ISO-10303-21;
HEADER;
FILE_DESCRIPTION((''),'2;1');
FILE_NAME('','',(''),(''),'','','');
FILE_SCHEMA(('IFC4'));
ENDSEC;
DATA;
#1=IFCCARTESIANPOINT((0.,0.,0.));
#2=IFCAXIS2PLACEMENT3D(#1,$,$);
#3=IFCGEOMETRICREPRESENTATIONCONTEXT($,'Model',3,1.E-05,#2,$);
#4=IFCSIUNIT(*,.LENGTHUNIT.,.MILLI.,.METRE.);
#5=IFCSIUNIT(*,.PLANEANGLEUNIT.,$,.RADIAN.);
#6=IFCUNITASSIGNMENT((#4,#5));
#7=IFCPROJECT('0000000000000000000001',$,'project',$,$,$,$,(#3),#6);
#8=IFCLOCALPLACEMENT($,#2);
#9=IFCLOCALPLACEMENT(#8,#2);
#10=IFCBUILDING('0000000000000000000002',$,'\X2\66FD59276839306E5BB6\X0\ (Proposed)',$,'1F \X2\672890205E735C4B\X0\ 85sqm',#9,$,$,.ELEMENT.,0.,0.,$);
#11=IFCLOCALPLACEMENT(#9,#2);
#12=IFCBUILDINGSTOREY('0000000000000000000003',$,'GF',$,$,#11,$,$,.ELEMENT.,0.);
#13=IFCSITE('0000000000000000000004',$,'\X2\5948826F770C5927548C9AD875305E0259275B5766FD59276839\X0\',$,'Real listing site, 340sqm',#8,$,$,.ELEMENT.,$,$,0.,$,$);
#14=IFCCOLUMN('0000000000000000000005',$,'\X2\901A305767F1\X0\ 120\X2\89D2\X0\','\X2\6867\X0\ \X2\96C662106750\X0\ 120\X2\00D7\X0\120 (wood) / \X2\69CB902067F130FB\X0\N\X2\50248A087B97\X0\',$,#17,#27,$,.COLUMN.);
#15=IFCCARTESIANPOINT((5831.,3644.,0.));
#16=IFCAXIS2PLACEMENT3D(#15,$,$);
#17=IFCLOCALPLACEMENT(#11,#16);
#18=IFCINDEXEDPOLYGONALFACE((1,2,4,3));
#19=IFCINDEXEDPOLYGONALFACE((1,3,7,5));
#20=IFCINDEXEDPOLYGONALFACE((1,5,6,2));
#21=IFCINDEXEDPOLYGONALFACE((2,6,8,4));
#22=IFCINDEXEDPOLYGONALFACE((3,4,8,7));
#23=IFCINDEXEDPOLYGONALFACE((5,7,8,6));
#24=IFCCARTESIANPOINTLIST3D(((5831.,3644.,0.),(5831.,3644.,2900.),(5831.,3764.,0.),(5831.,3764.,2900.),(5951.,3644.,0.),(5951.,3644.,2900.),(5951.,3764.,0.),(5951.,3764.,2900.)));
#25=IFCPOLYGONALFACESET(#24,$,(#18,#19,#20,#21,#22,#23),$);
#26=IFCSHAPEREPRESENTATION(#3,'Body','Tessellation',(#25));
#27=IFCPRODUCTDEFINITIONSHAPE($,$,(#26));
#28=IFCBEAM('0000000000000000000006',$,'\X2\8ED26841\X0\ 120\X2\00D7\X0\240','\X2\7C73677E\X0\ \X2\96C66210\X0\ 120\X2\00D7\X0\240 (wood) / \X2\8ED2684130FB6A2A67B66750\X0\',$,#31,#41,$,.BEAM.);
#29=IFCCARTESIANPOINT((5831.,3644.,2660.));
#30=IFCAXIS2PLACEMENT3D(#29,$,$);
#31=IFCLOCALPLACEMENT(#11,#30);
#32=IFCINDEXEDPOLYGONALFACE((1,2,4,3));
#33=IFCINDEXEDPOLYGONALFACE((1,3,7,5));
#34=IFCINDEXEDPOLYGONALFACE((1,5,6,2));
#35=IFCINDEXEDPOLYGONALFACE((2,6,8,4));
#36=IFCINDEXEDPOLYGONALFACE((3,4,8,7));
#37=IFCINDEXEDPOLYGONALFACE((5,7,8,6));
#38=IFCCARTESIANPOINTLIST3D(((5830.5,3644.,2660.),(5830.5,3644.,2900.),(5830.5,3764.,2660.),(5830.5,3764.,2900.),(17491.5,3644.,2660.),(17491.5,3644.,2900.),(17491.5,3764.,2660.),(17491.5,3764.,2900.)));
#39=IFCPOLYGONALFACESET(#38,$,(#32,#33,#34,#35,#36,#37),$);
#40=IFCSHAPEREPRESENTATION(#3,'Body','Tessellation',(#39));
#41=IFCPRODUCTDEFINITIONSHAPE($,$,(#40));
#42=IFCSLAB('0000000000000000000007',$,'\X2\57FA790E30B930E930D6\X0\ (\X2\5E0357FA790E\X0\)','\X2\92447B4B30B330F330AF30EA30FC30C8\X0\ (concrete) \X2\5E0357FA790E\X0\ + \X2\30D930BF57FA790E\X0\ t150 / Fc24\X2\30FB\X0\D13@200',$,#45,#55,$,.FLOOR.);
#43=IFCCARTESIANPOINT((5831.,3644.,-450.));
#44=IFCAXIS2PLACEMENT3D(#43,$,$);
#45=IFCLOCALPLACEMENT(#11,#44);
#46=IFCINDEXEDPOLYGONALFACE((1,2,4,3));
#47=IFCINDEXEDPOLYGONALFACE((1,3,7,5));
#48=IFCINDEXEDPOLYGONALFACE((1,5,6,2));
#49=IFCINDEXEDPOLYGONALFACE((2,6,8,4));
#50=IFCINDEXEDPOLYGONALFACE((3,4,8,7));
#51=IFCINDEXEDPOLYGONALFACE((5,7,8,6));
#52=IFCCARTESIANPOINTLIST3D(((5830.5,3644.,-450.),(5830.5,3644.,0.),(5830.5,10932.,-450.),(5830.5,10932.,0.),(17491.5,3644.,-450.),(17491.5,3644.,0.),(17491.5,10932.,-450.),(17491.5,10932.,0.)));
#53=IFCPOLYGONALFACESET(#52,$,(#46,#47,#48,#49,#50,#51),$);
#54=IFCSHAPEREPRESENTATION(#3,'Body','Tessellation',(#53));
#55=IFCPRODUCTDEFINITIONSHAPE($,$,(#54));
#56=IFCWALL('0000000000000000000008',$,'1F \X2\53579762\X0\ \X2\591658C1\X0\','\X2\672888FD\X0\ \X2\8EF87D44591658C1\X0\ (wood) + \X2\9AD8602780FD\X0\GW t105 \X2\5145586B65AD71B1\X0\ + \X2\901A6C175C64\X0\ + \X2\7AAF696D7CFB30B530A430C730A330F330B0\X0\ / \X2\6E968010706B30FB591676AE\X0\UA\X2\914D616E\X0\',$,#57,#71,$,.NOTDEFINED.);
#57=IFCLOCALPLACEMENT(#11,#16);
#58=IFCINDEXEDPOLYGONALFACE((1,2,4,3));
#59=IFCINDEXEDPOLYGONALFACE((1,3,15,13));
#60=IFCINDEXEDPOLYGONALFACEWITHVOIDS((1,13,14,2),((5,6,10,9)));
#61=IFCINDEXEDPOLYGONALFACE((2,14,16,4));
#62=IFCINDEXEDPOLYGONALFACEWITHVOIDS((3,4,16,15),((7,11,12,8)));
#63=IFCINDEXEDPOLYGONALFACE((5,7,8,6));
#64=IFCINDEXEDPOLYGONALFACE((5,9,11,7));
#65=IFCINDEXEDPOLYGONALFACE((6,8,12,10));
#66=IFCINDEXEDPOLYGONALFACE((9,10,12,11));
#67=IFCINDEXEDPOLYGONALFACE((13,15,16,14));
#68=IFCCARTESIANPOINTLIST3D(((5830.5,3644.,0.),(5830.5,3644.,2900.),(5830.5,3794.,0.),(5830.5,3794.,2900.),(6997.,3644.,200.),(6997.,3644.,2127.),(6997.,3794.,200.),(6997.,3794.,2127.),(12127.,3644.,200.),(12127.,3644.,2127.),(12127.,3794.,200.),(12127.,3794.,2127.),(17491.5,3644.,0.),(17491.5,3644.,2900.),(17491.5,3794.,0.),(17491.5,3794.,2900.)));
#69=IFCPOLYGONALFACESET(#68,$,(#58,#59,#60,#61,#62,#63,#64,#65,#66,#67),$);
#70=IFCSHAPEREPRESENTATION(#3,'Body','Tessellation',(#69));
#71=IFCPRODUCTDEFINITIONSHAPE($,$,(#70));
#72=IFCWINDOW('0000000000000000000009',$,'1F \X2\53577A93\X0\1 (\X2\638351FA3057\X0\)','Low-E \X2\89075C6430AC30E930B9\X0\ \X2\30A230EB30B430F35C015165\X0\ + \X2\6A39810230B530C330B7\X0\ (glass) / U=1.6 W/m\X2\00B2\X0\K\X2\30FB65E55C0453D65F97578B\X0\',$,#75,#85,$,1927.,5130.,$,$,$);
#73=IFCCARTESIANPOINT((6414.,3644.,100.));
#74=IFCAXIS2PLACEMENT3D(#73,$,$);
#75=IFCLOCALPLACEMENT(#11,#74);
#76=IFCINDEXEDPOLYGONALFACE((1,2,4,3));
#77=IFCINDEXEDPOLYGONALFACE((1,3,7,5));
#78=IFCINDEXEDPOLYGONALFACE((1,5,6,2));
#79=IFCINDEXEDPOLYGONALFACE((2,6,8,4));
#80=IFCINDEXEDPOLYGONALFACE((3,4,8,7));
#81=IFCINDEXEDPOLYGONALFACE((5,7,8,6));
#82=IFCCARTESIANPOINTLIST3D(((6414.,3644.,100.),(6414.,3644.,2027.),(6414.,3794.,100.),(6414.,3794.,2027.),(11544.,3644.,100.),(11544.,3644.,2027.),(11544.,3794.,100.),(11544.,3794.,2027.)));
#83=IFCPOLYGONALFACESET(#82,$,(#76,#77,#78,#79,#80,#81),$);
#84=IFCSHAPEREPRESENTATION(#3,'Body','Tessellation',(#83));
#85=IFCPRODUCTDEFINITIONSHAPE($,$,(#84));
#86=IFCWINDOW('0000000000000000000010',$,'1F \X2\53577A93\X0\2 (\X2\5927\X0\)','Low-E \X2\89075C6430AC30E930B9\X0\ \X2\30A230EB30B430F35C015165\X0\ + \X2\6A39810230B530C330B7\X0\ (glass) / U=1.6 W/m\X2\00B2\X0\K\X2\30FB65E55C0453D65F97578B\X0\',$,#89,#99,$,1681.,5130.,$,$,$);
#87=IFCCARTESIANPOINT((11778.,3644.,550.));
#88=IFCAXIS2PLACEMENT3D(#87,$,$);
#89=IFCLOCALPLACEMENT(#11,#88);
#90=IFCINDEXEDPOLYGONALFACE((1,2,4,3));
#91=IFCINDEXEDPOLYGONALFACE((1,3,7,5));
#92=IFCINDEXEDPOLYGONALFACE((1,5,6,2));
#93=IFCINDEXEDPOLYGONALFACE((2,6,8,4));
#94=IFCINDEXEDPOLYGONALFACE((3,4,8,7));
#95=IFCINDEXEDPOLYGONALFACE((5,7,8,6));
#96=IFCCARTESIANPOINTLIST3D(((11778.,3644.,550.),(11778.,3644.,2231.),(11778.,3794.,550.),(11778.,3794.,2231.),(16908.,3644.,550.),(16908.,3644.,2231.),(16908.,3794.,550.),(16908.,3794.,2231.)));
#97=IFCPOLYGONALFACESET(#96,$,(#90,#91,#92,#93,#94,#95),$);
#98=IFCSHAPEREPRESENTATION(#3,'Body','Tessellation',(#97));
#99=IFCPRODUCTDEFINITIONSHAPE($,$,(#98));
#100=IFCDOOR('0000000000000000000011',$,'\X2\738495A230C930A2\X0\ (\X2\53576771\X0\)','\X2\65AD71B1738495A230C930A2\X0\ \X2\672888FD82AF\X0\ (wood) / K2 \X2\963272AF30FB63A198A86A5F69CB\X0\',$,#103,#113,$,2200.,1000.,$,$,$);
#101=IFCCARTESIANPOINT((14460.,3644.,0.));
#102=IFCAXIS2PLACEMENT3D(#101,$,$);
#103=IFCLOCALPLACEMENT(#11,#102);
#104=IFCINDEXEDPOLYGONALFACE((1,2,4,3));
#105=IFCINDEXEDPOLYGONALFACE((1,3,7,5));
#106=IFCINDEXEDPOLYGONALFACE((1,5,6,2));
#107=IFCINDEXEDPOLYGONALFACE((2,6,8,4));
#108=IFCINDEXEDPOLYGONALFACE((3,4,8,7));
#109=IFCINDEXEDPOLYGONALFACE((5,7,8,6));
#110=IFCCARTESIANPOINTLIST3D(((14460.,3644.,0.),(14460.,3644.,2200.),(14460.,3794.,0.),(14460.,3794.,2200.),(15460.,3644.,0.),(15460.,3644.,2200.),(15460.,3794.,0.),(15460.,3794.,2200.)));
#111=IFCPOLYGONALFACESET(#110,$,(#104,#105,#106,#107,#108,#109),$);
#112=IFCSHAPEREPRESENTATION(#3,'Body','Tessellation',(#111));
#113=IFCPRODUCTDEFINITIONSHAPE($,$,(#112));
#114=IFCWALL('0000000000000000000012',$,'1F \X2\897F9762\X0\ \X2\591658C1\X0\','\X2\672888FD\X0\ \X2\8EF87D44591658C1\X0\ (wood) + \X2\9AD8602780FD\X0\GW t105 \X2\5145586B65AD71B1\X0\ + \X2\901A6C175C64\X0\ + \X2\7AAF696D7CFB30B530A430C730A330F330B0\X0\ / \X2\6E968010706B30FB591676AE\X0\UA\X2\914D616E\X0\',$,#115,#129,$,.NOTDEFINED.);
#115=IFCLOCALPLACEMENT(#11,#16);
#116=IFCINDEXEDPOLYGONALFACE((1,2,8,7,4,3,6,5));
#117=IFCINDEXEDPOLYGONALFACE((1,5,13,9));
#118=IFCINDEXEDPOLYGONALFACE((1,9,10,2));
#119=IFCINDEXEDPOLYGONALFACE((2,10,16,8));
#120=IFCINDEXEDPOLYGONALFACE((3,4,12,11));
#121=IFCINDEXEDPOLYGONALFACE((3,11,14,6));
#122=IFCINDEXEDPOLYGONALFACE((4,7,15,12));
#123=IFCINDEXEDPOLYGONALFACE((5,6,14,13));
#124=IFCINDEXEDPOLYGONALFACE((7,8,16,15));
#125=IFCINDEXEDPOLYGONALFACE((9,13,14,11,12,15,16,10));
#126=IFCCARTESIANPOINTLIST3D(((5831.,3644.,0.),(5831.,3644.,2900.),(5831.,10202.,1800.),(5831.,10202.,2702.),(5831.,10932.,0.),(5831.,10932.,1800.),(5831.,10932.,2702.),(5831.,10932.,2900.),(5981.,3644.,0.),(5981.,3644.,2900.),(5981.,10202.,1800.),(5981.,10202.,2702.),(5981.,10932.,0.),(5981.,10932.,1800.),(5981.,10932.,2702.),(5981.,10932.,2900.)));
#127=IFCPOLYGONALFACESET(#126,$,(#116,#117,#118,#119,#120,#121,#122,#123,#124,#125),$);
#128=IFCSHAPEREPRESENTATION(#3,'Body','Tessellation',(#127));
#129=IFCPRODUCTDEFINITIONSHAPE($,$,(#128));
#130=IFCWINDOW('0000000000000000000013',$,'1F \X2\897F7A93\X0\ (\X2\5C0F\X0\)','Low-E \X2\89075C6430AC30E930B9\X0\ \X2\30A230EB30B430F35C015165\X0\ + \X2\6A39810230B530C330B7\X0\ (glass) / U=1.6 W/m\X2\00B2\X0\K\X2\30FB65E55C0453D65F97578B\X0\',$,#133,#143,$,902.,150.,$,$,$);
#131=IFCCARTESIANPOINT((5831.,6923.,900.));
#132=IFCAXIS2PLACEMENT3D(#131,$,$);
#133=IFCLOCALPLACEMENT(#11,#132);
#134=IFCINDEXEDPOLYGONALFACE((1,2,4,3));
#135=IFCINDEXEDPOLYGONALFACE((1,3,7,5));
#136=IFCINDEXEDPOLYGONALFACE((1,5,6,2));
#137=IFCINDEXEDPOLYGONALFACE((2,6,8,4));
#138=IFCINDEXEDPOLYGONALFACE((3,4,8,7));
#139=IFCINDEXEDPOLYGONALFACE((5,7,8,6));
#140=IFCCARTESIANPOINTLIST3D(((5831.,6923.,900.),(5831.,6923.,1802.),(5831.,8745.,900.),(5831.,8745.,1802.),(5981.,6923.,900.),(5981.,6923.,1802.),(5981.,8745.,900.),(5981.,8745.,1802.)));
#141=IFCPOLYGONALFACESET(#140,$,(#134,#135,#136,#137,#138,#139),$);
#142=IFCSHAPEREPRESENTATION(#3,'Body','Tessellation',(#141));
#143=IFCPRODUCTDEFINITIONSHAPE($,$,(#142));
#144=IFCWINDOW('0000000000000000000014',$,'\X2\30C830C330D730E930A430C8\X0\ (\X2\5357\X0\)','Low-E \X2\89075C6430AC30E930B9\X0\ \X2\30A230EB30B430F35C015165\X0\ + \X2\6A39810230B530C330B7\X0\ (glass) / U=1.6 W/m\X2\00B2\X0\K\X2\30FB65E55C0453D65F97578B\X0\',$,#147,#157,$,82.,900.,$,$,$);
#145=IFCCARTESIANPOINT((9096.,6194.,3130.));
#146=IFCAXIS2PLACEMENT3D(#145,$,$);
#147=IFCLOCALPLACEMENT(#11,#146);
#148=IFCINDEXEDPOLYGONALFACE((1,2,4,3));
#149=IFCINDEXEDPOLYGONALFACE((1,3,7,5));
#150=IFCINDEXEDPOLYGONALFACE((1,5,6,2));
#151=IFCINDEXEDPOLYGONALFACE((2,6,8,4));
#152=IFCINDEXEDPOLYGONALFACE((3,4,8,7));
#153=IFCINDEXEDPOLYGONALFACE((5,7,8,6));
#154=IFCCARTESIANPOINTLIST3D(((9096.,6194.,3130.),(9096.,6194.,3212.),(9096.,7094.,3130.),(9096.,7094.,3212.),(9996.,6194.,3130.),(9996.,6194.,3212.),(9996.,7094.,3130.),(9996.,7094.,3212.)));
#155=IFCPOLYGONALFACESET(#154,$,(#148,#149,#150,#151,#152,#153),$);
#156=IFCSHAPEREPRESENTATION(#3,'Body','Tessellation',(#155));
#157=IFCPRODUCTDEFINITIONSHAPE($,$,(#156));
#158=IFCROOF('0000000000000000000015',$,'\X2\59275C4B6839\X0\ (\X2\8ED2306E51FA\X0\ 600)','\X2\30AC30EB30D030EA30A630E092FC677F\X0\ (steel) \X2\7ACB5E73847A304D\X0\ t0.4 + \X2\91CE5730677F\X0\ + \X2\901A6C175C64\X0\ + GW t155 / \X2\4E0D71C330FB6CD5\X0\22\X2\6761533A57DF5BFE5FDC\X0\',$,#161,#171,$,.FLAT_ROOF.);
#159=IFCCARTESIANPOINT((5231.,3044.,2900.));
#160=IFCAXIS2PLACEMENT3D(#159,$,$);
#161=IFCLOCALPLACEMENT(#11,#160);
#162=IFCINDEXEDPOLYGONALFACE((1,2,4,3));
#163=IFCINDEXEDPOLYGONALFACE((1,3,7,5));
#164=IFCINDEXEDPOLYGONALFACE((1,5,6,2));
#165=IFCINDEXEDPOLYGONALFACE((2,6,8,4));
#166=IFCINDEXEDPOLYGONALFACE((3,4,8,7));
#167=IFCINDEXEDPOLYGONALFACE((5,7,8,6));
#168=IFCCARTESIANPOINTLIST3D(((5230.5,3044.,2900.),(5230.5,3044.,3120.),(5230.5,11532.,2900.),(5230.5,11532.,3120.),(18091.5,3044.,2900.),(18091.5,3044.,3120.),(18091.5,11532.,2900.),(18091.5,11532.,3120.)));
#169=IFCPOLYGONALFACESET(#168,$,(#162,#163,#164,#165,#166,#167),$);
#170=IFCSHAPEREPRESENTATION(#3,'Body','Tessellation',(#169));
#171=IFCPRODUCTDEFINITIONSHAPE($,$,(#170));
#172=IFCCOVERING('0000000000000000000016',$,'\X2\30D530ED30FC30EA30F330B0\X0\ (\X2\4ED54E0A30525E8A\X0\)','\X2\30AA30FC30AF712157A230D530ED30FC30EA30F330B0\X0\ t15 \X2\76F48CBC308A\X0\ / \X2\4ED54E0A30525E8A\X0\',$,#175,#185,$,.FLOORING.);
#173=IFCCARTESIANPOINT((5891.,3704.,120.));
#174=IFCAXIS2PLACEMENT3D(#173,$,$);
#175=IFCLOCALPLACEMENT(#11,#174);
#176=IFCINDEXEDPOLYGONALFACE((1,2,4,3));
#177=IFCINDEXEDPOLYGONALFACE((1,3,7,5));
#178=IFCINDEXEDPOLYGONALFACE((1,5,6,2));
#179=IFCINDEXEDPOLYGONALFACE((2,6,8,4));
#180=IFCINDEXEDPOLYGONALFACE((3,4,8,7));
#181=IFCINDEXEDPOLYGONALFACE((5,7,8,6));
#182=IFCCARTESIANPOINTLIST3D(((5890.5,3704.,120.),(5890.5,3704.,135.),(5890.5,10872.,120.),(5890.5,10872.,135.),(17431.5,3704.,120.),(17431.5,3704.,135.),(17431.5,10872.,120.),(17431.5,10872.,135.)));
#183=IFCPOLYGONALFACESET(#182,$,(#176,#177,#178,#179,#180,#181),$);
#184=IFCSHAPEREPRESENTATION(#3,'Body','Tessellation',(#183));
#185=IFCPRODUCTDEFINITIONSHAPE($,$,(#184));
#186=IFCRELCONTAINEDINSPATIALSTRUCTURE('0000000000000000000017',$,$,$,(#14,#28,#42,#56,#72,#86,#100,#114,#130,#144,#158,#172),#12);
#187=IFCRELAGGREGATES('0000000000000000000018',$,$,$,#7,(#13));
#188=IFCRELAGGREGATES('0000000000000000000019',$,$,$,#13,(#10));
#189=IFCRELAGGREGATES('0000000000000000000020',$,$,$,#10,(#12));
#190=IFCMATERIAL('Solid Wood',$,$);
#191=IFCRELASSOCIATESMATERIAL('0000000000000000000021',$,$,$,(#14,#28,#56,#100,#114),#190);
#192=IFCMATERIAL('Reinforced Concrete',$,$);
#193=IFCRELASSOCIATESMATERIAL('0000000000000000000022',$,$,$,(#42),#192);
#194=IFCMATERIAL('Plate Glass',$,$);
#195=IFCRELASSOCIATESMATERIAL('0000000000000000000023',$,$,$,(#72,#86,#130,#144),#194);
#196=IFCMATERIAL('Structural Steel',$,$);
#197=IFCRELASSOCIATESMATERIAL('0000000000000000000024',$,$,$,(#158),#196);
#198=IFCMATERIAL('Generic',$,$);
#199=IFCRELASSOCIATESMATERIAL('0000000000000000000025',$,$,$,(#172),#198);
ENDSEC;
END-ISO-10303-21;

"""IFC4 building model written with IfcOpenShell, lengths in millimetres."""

from ifc_helpers import new_model, si_unit, frame, frame_2d, origin, place, context, project, spatial, rectangle, extrude, material, element, fill, save


model = new_model("IFC4")

# Units and contexts
model_context = context("Model", 3, precision=1e-05, world=origin())
ifc_project = project(units=[si_unit("LENGTHUNIT", "METRE", prefix="MILLI"), si_unit("PLANEANGLEUNIT", "RADIAN")], contexts=[model_context])

# Site, building, storey
site_placement = place(None, origin())
site = spatial("IfcSite", under=ifc_project, at=site_placement, Name="奈良県大和高田市大字曽大根", ObjectType="Real listing site, 340sqm", CompositionType="ELEMENT", RefElevation=0.0)
building_placement = place(site_placement, origin())
building = spatial("IfcBuilding", under=site, at=building_placement, Name="曽大根の家 (Proposed)", ObjectType="1F 木造平屋 85sqm", CompositionType="ELEMENT", ElevationOfRefHeight=0.0, ElevationOfTerrain=0.0)
storey_placement = place(building_placement, origin())
storey = spatial("IfcBuildingStorey", under=building, at=storey_placement, Name="GF", CompositionType="ELEMENT", Elevation=0.0)

# Column
ifc_material_1 = material(Name="Solid Wood")
column_1_placement = place(storey_placement, frame((5831.0, 3644.0, 0.0)))
element("IfcColumn", 1, at=column_1_placement, inside=storey, material=ifc_material_1, Name="通し柱 120角", Description="桧 集成材 120×120 (wood) / 構造柱・N値計算", PredefinedType="COLUMN", context=model_context, shape_type="SweptSolid", body=[
    extrude(rectangle(XDim=120.0, YDim=120.0, at=frame_2d((60.0, 60.0))), frame((5831.0, 3644.0, 0.0)), (0.0, 0.0, 1.0), 2900.0),
])

# Beam
beam_1_placement = place(storey_placement, frame((5831.0, 3644.0, 2660.0)))
element("IfcBeam", 2, at=beam_1_placement, inside=storey, material=ifc_material_1, Name="軒桁 120×240", Description="米松 集成 120×240 (wood) / 軒桁・横架材", PredefinedType="BEAM", context=model_context, shape_type="SweptSolid", body=[
    extrude(rectangle(XDim=11661.0, YDim=120.0, at=frame_2d((5830.0, 60.0))), frame((5831.0, 3644.0, 2660.0)), (0.0, 0.0, 1.0), 240.0),
])

# Slab
ifc_material_2 = material(Name="Reinforced Concrete")
slab_1_placement = place(storey_placement, frame((5831.0, 3644.0, -450.0)))
element("IfcSlab", 3, at=slab_1_placement, inside=storey, material=ifc_material_2, Name="基礎スラブ (布基礎)", Description="鉄筋コンクリート (concrete) 布基礎 + ベタ基礎 t150 / Fc24・D13@200", PredefinedType="FLOOR", context=model_context, shape_type="SweptSolid", body=[
    extrude(rectangle(XDim=11661.0, YDim=7288.0, at=frame_2d((5830.0, 3644.0))), frame((5831.0, 3644.0, -450.0)), (0.0, 0.0, 1.0), 450.0),
])

# Wall, openings, windows, door
wall_1_placement = place(storey_placement, frame((5831.0, 3644.0, 0.0)))
wall_1 = element("IfcWall", 4, at=wall_1_placement, inside=storey, material=ifc_material_1, Name="1F 南面 外壁", Description="木製 軸組外壁 (wood) + 高性能GW t105 充填断熱 + 通気層 + 窯業系サイディング / 準耐火・外皮UA配慮", PredefinedType="NOTDEFINED", context=model_context, shape_type="SweptSolid", body=[
    extrude(rectangle(XDim=11661.0, YDim=150.0, at=frame_2d((5830.0, 75.0))), frame((5831.0, 3644.0, 0.0)), (0.0, 0.0, 1.0), 2900.0),
])
opening_1_placement = place(storey_placement, frame((6414.0, 3644.0, 100.0)))
opening_1 = element("IfcOpeningElement", 5, at=opening_1_placement, cuts=wall_1, PredefinedType="NOTDEFINED", context=model_context, shape_type="SweptSolid", body=[
    extrude(rectangle(XDim=5130.0, YDim=150.0, at=frame_2d((2565.0, 75.0))), frame((6414.0, 3644.0, 100.0)), (0.0, 0.0, 1.0), 1927.0),
])
opening_2_placement = place(storey_placement, frame((11778.0, 3644.0, 550.0)))
opening_2 = element("IfcOpeningElement", 6, at=opening_2_placement, cuts=wall_1, PredefinedType="NOTDEFINED", context=model_context, shape_type="SweptSolid", body=[
    extrude(rectangle(XDim=5130.0, YDim=150.0, at=frame_2d((2565.0, 75.0))), frame((11778.0, 3644.0, 550.0)), (0.0, 0.0, 1.0), 1681.0),
])
opening_3_placement = place(storey_placement, frame((14460.0, 3644.0, 0.0)))
opening_3 = element("IfcOpeningElement", 7, at=opening_3_placement, cuts=wall_1, PredefinedType="NOTDEFINED", context=model_context, shape_type="SweptSolid", body=[
    extrude(rectangle(XDim=1000.0, YDim=150.0, at=frame_2d((500.0, 75.0))), frame((14460.0, 3644.0, 0.0)), (0.0, 0.0, 1.0), 2200.0),
])
ifc_material_3 = material(Name="Plate Glass")
window_1_placement = place(storey_placement, frame((6414.0, 3644.0, 100.0)))
window_1 = element("IfcWindow", 8, at=window_1_placement, inside=storey, material=ifc_material_3, Name="1F 南窓1 (掃出し)", Description="Low-E 複層ガラス アルゴン封入 + 樹脂サッシ (glass) / U=1.6 W/m²K・日射取得型", OverallHeight=1927.0, OverallWidth=5130.0, context=model_context, shape_type="SweptSolid", body=[
    extrude(rectangle(XDim=5130.0, YDim=150.0, at=frame_2d((2565.0, 75.0))), frame((6414.0, 3644.0, 100.0)), (0.0, 0.0, 1.0), 1927.0),
])
fill(opening_1, window_1)
window_2_placement = place(storey_placement, frame((11778.0, 3644.0, 550.0)))
window_2 = element("IfcWindow", 9, at=window_2_placement, inside=storey, material=ifc_material_3, Name="1F 南窓2 (大)", Description="Low-E 複層ガラス アルゴン封入 + 樹脂サッシ (glass) / U=1.6 W/m²K・日射取得型", OverallHeight=1681.0, OverallWidth=5130.0, context=model_context, shape_type="SweptSolid", body=[
    extrude(rectangle(XDim=5130.0, YDim=150.0, at=frame_2d((2565.0, 75.0))), frame((11778.0, 3644.0, 550.0)), (0.0, 0.0, 1.0), 1681.0),
])
fill(opening_2, window_2)
door_placement = place(storey_placement, frame((14460.0, 3644.0, 0.0)))
door = element("IfcDoor", 10, at=door_placement, inside=storey, material=ifc_material_1, Name="玄関ドア (南東)", Description="断熱玄関ドア 木製芯 (wood) / K2 防犯・採風機構", OverallHeight=2200.0, OverallWidth=1000.0, context=model_context, shape_type="SweptSolid", body=[
    extrude(rectangle(XDim=1000.0, YDim=150.0, at=frame_2d((500.0, 75.0))), frame((14460.0, 3644.0, 0.0)), (0.0, 0.0, 1.0), 2200.0),
])
fill(opening_3, door)

# Wall, opening, window
wall_2_placement = place(storey_placement, frame((5831.0, 3644.0, 0.0)))
wall_2 = element("IfcWall", 11, at=wall_2_placement, inside=storey, material=ifc_material_1, Name="1F 西面 外壁", Description="木製 軸組外壁 (wood) + 高性能GW t105 充填断熱 + 通気層 + 窯業系サイディング / 準耐火・外皮UA配慮", PredefinedType="NOTDEFINED", context=model_context, shape_type="SweptSolid", body=[
    extrude(rectangle(XDim=150.0, YDim=7288.0, at=frame_2d((75.0, 3644.0))), frame((5831.0, 3644.0, 0.0)), (0.0, 0.0, 1.0), 2900.0),
])
opening_4_placement = place(storey_placement, frame((5831.0, 6923.0, 900.0)))
opening_4 = element("IfcOpeningElement", 12, at=opening_4_placement, cuts=wall_2, PredefinedType="NOTDEFINED", context=model_context, shape_type="SweptSolid", body=[
    extrude(rectangle(XDim=150.0, YDim=1822.0, at=frame_2d((75.0, 911.0))), frame((5831.0, 6923.0, 900.0)), (0.0, 0.0, 1.0), 902.0),
])
window_3_placement = place(storey_placement, frame((5831.0, 6923.0, 900.0)))
window_3 = element("IfcWindow", 13, at=window_3_placement, inside=storey, material=ifc_material_3, Name="1F 西窓 (小)", Description="Low-E 複層ガラス アルゴン封入 + 樹脂サッシ (glass) / U=1.6 W/m²K・日射取得型", OverallHeight=902.0, OverallWidth=150.0, context=model_context, shape_type="SweptSolid", body=[
    extrude(rectangle(XDim=150.0, YDim=1822.0, at=frame_2d((75.0, 911.0))), frame((5831.0, 6923.0, 900.0)), (0.0, 0.0, 1.0), 902.0),
])
fill(opening_4, window_3)

# Window
window_4_placement = place(storey_placement, frame((9096.0, 6194.0, 3130.0)))
element("IfcWindow", 14, at=window_4_placement, inside=storey, material=ifc_material_3, Name="トップライト (南)", Description="Low-E 複層ガラス アルゴン封入 + 樹脂サッシ (glass) / U=1.6 W/m²K・日射取得型", OverallHeight=82.0, OverallWidth=900.0, context=model_context, shape_type="SweptSolid", body=[
    extrude(rectangle(XDim=900.0, YDim=900.0, at=frame_2d((450.0, 450.0))), frame((9096.0, 6194.0, 3130.0)), (0.0, 0.0, 1.0), 82.0),
])

# Roof
ifc_material_4 = material(Name="Structural Steel")
roof_placement = place(storey_placement, frame((5231.0, 3044.0, 2900.0)))
element("IfcRoof", 15, at=roof_placement, inside=storey, material=ifc_material_4, Name="大屋根 (軒の出 600)", Description="ガルバリウム鋼板 (steel) 立平葺き t0.4 + 野地板 + 通気層 + GW t155 / 不燃・法22条区域対応", PredefinedType="FLAT_ROOF", context=model_context, shape_type="SweptSolid", body=[
    extrude(rectangle(XDim=12861.0, YDim=8488.0, at=frame_2d((6430.0, 4244.0))), frame((5231.0, 3044.0, 2900.0)), (0.0, 0.0, 1.0), 220.0),
])

# Covering
ifc_material_5 = material(Name="Generic")
covering_1_placement = place(storey_placement, frame((5891.0, 3704.0, 120.0)))
element("IfcCovering", 16, at=covering_1_placement, inside=storey, material=ifc_material_5, Name="フローリング (仕上げ床)", Description="オーク無垢フローリング t15 直貼り / 仕上げ床", PredefinedType="FLOORING", context=model_context, shape_type="SweptSolid", body=[
    extrude(rectangle(XDim=11541.0, YDim=7168.0, at=frame_2d((5770.0, 3584.0))), frame((5891.0, 3704.0, 120.0)), (0.0, 0.0, 1.0), 15.0),
])

save(model, "model.ifc")
